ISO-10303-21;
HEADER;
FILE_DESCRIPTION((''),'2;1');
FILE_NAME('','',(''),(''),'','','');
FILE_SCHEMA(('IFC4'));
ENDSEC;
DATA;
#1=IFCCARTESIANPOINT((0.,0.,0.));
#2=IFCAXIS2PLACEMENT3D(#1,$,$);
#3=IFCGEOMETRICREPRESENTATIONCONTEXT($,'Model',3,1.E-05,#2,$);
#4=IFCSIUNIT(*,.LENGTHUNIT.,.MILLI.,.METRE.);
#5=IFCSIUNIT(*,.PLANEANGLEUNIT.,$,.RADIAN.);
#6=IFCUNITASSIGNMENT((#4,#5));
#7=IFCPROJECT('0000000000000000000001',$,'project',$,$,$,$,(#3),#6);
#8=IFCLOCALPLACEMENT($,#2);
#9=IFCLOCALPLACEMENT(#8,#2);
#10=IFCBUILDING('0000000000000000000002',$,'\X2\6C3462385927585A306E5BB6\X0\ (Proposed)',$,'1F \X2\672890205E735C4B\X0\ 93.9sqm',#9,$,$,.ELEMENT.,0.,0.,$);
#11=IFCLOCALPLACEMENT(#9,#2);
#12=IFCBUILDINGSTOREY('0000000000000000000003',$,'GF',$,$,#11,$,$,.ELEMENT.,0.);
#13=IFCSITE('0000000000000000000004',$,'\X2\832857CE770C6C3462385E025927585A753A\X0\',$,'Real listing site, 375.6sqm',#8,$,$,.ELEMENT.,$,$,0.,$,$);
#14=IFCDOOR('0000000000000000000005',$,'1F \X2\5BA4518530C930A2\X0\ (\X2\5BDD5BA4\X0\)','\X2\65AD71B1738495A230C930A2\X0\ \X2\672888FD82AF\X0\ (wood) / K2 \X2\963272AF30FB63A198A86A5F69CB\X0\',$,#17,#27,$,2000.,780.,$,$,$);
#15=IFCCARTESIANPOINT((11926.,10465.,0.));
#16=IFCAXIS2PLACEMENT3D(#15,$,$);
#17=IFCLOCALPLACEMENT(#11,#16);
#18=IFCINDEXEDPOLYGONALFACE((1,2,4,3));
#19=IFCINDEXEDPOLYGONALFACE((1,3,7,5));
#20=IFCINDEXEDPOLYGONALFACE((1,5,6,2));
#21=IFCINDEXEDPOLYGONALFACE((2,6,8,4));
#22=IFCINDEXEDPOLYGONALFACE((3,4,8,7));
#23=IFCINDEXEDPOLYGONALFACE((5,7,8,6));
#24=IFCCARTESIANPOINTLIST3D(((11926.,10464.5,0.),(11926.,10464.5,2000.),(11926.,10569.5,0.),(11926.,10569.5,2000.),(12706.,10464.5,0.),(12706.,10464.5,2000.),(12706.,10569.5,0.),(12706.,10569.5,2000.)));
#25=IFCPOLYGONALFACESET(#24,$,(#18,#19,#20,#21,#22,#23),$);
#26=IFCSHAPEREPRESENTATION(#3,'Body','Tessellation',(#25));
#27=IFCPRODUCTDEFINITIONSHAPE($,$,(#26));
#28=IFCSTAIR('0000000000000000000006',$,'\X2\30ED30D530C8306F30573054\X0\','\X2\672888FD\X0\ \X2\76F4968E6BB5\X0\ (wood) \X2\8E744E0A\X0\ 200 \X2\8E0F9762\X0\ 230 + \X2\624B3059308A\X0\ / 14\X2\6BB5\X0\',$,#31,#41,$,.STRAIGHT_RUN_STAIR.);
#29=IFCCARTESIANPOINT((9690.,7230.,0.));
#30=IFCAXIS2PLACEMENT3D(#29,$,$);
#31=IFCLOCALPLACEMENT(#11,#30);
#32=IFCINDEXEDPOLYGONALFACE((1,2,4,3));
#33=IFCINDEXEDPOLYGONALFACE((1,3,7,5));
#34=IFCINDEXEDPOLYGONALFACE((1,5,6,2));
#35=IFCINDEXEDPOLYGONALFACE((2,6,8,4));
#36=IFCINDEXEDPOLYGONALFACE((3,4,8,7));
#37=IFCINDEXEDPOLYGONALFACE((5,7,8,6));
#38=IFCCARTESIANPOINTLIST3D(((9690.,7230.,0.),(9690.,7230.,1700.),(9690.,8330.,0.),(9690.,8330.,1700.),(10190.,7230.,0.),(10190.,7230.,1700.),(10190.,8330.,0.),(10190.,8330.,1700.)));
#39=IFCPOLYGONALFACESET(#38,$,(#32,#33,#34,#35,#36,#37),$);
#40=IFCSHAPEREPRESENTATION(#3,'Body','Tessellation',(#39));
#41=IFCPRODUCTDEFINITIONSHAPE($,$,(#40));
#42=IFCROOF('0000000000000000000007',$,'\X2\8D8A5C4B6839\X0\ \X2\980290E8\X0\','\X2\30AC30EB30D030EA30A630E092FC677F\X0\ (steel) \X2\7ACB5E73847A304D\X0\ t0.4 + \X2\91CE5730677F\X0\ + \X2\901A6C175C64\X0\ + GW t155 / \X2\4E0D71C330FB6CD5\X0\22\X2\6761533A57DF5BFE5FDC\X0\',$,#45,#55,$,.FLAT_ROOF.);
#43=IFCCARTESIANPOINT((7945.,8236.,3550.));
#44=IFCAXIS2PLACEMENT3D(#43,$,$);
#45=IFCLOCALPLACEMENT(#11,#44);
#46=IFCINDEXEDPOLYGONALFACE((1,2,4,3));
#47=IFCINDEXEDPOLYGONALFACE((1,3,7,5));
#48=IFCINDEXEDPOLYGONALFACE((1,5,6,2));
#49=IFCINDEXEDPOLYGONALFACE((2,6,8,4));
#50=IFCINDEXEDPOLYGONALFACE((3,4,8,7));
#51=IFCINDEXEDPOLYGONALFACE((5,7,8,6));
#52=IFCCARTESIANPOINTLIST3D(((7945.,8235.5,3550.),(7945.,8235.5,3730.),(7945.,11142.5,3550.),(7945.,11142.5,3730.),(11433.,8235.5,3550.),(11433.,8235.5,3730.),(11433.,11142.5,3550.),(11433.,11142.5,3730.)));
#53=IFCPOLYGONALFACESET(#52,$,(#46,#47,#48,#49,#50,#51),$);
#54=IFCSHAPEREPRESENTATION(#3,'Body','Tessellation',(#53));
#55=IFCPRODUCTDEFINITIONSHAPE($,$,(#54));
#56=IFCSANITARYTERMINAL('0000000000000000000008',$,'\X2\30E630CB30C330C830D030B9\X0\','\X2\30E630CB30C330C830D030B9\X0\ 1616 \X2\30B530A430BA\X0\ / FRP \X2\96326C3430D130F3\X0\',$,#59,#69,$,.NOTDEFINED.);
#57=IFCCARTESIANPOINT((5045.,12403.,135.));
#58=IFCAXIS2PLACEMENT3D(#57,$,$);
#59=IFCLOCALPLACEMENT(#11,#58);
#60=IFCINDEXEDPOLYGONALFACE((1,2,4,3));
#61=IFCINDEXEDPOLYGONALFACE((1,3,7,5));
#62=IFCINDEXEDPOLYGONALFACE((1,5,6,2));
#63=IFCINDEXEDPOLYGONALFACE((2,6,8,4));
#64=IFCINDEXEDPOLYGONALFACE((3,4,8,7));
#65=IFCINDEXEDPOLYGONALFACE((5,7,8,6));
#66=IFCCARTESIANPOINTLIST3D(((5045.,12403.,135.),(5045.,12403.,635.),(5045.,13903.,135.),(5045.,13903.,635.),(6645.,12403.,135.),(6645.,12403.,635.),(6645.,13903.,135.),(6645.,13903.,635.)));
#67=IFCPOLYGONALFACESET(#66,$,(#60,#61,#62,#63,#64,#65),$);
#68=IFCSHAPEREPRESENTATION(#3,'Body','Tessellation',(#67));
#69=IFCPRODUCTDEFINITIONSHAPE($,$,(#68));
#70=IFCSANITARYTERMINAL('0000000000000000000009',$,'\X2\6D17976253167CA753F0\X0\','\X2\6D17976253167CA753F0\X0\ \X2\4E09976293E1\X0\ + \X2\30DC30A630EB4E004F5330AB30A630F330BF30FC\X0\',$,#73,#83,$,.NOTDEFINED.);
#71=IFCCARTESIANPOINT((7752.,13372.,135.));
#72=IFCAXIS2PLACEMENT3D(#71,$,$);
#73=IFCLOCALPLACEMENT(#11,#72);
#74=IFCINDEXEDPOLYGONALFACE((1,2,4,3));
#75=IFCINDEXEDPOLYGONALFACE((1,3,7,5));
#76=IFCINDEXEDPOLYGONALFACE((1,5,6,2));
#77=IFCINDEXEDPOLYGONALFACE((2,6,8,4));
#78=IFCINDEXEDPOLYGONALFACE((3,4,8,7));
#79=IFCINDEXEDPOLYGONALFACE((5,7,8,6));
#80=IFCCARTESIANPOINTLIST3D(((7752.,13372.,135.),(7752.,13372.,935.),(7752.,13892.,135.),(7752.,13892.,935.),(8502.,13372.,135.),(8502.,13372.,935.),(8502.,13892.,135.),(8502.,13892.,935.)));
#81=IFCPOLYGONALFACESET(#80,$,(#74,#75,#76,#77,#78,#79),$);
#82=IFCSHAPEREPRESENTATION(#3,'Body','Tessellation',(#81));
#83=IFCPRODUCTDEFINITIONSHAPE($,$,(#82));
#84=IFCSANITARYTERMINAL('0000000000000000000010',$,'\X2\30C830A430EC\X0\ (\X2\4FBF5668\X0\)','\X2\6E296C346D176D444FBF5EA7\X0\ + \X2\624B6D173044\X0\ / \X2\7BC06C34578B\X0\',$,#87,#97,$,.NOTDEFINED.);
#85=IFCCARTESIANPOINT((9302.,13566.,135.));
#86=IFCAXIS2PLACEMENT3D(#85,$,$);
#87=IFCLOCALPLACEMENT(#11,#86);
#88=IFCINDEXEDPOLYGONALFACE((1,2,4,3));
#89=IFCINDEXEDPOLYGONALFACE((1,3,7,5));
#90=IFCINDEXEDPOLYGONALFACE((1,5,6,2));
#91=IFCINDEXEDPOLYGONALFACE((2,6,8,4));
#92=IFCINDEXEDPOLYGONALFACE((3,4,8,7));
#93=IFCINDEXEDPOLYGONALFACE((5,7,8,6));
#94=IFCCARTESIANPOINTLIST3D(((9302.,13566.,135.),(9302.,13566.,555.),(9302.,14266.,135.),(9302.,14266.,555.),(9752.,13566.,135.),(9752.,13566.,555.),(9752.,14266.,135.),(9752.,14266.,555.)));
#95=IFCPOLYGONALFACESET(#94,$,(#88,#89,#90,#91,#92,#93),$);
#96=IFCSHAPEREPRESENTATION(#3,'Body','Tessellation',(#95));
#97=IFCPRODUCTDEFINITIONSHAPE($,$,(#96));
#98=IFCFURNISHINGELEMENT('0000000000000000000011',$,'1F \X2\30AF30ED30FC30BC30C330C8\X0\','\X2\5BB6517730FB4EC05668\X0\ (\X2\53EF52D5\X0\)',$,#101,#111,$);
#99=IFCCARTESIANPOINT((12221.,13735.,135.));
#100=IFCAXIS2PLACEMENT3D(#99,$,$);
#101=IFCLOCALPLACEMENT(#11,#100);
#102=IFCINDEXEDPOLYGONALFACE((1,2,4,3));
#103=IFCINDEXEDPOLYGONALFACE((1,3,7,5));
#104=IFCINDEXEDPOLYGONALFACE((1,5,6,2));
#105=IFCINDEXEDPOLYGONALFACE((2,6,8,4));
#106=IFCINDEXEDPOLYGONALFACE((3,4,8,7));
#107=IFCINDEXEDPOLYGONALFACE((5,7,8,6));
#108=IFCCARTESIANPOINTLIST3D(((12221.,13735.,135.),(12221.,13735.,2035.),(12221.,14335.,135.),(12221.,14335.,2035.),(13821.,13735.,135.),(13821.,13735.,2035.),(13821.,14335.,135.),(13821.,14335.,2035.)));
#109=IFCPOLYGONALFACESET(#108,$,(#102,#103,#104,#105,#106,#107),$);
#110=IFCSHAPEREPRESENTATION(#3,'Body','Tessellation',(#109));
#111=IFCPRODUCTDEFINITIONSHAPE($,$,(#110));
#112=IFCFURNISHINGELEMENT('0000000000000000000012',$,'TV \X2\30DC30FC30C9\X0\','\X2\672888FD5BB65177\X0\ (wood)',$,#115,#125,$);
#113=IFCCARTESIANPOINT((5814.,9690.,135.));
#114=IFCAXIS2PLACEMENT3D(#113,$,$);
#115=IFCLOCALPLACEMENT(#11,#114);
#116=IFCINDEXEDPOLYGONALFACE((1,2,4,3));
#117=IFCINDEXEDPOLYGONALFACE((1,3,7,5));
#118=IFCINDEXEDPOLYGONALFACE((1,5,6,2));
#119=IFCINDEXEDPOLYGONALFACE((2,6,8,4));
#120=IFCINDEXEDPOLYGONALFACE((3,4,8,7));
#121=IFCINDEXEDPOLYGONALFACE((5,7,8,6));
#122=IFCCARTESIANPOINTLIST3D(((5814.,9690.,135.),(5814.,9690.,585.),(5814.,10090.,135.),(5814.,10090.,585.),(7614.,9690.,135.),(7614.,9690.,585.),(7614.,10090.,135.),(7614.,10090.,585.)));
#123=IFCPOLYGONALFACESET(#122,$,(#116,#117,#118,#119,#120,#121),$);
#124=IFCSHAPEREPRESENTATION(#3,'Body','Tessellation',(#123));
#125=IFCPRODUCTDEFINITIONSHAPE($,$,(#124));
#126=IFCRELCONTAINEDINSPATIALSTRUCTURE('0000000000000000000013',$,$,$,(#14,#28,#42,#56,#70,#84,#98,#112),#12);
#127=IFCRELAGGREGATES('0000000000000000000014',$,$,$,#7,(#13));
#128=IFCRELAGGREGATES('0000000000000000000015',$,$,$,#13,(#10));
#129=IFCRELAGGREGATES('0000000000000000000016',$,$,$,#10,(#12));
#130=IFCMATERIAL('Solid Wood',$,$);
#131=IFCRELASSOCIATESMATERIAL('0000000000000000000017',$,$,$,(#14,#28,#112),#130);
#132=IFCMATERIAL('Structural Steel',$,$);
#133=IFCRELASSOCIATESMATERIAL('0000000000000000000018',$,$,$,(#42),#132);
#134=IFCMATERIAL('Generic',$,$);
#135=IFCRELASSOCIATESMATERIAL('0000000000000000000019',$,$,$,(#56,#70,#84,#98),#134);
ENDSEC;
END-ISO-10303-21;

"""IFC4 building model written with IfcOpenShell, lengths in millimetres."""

from ifc_helpers import new_model, si_unit, frame, frame_2d, origin, place, context, project, spatial, rectangle, extrude, material, element, save


model = new_model("IFC4")

# Units and contexts
model_context = context("Model", 3, precision=1e-05, world=origin())
ifc_project = project(units=[si_unit("LENGTHUNIT", "METRE", prefix="MILLI"), si_unit("PLANEANGLEUNIT", "RADIAN")], contexts=[model_context])

# Site, building, storey
site_placement = place(None, origin())
site = spatial("IfcSite", under=ifc_project, at=site_placement, Name="茨城県水戸市大塚町", ObjectType="Real listing site, 375.6sqm", CompositionType="ELEMENT", RefElevation=0.0)
building_placement = place(site_placement, origin())
building = spatial("IfcBuilding", under=site, at=building_placement, Name="水戸大塚の家 (Proposed)", ObjectType="1F 木造平屋 93.9sqm", CompositionType="ELEMENT", ElevationOfRefHeight=0.0, ElevationOfTerrain=0.0)
storey_placement = place(building_placement, origin())
storey = spatial("IfcBuildingStorey", under=building, at=storey_placement, Name="GF", CompositionType="ELEMENT", Elevation=0.0)

# Shared definitions
ifc_material_1 = material(Name="Solid Wood")

# Door
door_1_placement = place(storey_placement, frame((11926.0, 10465.0, 0.0)))
element("IfcDoor", 1, at=door_1_placement, inside=storey, material=ifc_material_1, Name="1F 室内ドア (寝室)", Description="断熱玄関ドア 木製芯 (wood) / K2 防犯・採風機構", OverallHeight=2000.0, OverallWidth=780.0, context=model_context, shape_type="SweptSolid", body=[
    extrude(rectangle(XDim=780.0, YDim=105.0, at=frame_2d((390.0, 52.0))), frame((11926.0, 10465.0, 0.0)), (0.0, 0.0, 1.0), 2000.0),
])

# Stair
stair_placement = place(storey_placement, frame((9690.0, 7230.0, 0.0)))
element("IfcStair", 2, at=stair_placement, inside=storey, material=ifc_material_1, Name="ロフトはしご", Description="木製 直階段 (wood) 蹴上 200 踏面 230 + 手すり / 14段", PredefinedType="STRAIGHT_RUN_STAIR", context=model_context, shape_type="SweptSolid", body=[
    extrude(rectangle(XDim=500.0, YDim=1100.0, at=frame_2d((250.0, 550.0))), frame((9690.0, 7230.0, 0.0)), (0.0, 0.0, 1.0), 1700.0),
])

# Roof
ifc_material_2 = material(Name="Structural Steel")
roof_placement = place(storey_placement, frame((7945.0, 8236.0, 3550.0)))
element("IfcRoof", 3, at=roof_placement, inside=storey, material=ifc_material_2, Name="越屋根 頂部", Description="ガルバリウム鋼板 (steel) 立平葺き t0.4 + 野地板 + 通気層 + GW t155 / 不燃・法22条区域対応", PredefinedType="FLAT_ROOF", context=model_context, shape_type="SweptSolid", body=[
    extrude(rectangle(XDim=3488.0, YDim=2907.0, at=frame_2d((1744.0, 1453.0))), frame((7945.0, 8236.0, 3550.0)), (0.0, 0.0, 1.0), 180.0),
])

# Sanitary terminals
ifc_material_3 = material(Name="Generic")
sanitary_terminal_1_placement = place(storey_placement, frame((5045.0, 12403.0, 135.0)))
element("IfcSanitaryTerminal", 4, at=sanitary_terminal_1_placement, inside=storey, material=ifc_material_3, Name="ユニットバス", Description="ユニットバス 1616 サイズ / FRP 防水パン", PredefinedType="NOTDEFINED", context=model_context, shape_type="SweptSolid", body=[
    extrude(rectangle(XDim=1600.0, YDim=1500.0, at=frame_2d((800.0, 750.0))), frame((5045.0, 12403.0, 135.0)), (0.0, 0.0, 1.0), 500.0),
])
sanitary_terminal_2_placement = place(storey_placement, frame((7752.0, 13372.0, 135.0)))
element("IfcSanitaryTerminal", 5, at=sanitary_terminal_2_placement, inside=storey, material=ifc_material_3, Name="洗面化粧台", Description="洗面化粧台 三面鏡 + ボウル一体カウンター", PredefinedType="NOTDEFINED", context=model_context, shape_type="SweptSolid", body=[
    extrude(rectangle(XDim=750.0, YDim=520.0, at=frame_2d((375.0, 260.0))), frame((7752.0, 13372.0, 135.0)), (0.0, 0.0, 1.0), 800.0),
])
sanitary_terminal_3_placement = place(storey_placement, frame((9302.0, 13566.0, 135.0)))
element("IfcSanitaryTerminal", 6, at=sanitary_terminal_3_placement, inside=storey, material=ifc_material_3, Name="トイレ (便器)", Description="温水洗浄便座 + 手洗い / 節水型", PredefinedType="NOTDEFINED", context=model_context, shape_type="SweptSolid", body=[
    extrude(rectangle(XDim=450.0, YDim=700.0, at=frame_2d((225.0, 350.0))), frame((9302.0, 13566.0, 135.0)), (0.0, 0.0, 1.0), 420.0),
])

# Furnishing elements
furnishing_1_placement = place(storey_placement, frame((12221.0, 13735.0, 135.0)))
element("IfcFurnishingElement", 7, at=furnishing_1_placement, inside=storey, material=ifc_material_3, Name="1F クローゼット", Description="家具・什器 (可動)", context=model_context, shape_type="SweptSolid", body=[
    extrude(rectangle(XDim=1600.0, YDim=600.0, at=frame_2d((800.0, 300.0))), frame((12221.0, 13735.0, 135.0)), (0.0, 0.0, 1.0), 1900.0),
])
furnishing_2_placement = place(storey_placement, frame((5814.0, 9690.0, 135.0)))
element("IfcFurnishingElement", 8, at=furnishing_2_placement, inside=storey, material=ifc_material_1, Name="TV ボード", Description="木製家具 (wood)", context=model_context, shape_type="SweptSolid", body=[
    extrude(rectangle(XDim=1800.0, YDim=400.0, at=frame_2d((900.0, 200.0))), frame((5814.0, 9690.0, 135.0)), (0.0, 0.0, 1.0), 450.0),
])

save(model, "model.ifc")
